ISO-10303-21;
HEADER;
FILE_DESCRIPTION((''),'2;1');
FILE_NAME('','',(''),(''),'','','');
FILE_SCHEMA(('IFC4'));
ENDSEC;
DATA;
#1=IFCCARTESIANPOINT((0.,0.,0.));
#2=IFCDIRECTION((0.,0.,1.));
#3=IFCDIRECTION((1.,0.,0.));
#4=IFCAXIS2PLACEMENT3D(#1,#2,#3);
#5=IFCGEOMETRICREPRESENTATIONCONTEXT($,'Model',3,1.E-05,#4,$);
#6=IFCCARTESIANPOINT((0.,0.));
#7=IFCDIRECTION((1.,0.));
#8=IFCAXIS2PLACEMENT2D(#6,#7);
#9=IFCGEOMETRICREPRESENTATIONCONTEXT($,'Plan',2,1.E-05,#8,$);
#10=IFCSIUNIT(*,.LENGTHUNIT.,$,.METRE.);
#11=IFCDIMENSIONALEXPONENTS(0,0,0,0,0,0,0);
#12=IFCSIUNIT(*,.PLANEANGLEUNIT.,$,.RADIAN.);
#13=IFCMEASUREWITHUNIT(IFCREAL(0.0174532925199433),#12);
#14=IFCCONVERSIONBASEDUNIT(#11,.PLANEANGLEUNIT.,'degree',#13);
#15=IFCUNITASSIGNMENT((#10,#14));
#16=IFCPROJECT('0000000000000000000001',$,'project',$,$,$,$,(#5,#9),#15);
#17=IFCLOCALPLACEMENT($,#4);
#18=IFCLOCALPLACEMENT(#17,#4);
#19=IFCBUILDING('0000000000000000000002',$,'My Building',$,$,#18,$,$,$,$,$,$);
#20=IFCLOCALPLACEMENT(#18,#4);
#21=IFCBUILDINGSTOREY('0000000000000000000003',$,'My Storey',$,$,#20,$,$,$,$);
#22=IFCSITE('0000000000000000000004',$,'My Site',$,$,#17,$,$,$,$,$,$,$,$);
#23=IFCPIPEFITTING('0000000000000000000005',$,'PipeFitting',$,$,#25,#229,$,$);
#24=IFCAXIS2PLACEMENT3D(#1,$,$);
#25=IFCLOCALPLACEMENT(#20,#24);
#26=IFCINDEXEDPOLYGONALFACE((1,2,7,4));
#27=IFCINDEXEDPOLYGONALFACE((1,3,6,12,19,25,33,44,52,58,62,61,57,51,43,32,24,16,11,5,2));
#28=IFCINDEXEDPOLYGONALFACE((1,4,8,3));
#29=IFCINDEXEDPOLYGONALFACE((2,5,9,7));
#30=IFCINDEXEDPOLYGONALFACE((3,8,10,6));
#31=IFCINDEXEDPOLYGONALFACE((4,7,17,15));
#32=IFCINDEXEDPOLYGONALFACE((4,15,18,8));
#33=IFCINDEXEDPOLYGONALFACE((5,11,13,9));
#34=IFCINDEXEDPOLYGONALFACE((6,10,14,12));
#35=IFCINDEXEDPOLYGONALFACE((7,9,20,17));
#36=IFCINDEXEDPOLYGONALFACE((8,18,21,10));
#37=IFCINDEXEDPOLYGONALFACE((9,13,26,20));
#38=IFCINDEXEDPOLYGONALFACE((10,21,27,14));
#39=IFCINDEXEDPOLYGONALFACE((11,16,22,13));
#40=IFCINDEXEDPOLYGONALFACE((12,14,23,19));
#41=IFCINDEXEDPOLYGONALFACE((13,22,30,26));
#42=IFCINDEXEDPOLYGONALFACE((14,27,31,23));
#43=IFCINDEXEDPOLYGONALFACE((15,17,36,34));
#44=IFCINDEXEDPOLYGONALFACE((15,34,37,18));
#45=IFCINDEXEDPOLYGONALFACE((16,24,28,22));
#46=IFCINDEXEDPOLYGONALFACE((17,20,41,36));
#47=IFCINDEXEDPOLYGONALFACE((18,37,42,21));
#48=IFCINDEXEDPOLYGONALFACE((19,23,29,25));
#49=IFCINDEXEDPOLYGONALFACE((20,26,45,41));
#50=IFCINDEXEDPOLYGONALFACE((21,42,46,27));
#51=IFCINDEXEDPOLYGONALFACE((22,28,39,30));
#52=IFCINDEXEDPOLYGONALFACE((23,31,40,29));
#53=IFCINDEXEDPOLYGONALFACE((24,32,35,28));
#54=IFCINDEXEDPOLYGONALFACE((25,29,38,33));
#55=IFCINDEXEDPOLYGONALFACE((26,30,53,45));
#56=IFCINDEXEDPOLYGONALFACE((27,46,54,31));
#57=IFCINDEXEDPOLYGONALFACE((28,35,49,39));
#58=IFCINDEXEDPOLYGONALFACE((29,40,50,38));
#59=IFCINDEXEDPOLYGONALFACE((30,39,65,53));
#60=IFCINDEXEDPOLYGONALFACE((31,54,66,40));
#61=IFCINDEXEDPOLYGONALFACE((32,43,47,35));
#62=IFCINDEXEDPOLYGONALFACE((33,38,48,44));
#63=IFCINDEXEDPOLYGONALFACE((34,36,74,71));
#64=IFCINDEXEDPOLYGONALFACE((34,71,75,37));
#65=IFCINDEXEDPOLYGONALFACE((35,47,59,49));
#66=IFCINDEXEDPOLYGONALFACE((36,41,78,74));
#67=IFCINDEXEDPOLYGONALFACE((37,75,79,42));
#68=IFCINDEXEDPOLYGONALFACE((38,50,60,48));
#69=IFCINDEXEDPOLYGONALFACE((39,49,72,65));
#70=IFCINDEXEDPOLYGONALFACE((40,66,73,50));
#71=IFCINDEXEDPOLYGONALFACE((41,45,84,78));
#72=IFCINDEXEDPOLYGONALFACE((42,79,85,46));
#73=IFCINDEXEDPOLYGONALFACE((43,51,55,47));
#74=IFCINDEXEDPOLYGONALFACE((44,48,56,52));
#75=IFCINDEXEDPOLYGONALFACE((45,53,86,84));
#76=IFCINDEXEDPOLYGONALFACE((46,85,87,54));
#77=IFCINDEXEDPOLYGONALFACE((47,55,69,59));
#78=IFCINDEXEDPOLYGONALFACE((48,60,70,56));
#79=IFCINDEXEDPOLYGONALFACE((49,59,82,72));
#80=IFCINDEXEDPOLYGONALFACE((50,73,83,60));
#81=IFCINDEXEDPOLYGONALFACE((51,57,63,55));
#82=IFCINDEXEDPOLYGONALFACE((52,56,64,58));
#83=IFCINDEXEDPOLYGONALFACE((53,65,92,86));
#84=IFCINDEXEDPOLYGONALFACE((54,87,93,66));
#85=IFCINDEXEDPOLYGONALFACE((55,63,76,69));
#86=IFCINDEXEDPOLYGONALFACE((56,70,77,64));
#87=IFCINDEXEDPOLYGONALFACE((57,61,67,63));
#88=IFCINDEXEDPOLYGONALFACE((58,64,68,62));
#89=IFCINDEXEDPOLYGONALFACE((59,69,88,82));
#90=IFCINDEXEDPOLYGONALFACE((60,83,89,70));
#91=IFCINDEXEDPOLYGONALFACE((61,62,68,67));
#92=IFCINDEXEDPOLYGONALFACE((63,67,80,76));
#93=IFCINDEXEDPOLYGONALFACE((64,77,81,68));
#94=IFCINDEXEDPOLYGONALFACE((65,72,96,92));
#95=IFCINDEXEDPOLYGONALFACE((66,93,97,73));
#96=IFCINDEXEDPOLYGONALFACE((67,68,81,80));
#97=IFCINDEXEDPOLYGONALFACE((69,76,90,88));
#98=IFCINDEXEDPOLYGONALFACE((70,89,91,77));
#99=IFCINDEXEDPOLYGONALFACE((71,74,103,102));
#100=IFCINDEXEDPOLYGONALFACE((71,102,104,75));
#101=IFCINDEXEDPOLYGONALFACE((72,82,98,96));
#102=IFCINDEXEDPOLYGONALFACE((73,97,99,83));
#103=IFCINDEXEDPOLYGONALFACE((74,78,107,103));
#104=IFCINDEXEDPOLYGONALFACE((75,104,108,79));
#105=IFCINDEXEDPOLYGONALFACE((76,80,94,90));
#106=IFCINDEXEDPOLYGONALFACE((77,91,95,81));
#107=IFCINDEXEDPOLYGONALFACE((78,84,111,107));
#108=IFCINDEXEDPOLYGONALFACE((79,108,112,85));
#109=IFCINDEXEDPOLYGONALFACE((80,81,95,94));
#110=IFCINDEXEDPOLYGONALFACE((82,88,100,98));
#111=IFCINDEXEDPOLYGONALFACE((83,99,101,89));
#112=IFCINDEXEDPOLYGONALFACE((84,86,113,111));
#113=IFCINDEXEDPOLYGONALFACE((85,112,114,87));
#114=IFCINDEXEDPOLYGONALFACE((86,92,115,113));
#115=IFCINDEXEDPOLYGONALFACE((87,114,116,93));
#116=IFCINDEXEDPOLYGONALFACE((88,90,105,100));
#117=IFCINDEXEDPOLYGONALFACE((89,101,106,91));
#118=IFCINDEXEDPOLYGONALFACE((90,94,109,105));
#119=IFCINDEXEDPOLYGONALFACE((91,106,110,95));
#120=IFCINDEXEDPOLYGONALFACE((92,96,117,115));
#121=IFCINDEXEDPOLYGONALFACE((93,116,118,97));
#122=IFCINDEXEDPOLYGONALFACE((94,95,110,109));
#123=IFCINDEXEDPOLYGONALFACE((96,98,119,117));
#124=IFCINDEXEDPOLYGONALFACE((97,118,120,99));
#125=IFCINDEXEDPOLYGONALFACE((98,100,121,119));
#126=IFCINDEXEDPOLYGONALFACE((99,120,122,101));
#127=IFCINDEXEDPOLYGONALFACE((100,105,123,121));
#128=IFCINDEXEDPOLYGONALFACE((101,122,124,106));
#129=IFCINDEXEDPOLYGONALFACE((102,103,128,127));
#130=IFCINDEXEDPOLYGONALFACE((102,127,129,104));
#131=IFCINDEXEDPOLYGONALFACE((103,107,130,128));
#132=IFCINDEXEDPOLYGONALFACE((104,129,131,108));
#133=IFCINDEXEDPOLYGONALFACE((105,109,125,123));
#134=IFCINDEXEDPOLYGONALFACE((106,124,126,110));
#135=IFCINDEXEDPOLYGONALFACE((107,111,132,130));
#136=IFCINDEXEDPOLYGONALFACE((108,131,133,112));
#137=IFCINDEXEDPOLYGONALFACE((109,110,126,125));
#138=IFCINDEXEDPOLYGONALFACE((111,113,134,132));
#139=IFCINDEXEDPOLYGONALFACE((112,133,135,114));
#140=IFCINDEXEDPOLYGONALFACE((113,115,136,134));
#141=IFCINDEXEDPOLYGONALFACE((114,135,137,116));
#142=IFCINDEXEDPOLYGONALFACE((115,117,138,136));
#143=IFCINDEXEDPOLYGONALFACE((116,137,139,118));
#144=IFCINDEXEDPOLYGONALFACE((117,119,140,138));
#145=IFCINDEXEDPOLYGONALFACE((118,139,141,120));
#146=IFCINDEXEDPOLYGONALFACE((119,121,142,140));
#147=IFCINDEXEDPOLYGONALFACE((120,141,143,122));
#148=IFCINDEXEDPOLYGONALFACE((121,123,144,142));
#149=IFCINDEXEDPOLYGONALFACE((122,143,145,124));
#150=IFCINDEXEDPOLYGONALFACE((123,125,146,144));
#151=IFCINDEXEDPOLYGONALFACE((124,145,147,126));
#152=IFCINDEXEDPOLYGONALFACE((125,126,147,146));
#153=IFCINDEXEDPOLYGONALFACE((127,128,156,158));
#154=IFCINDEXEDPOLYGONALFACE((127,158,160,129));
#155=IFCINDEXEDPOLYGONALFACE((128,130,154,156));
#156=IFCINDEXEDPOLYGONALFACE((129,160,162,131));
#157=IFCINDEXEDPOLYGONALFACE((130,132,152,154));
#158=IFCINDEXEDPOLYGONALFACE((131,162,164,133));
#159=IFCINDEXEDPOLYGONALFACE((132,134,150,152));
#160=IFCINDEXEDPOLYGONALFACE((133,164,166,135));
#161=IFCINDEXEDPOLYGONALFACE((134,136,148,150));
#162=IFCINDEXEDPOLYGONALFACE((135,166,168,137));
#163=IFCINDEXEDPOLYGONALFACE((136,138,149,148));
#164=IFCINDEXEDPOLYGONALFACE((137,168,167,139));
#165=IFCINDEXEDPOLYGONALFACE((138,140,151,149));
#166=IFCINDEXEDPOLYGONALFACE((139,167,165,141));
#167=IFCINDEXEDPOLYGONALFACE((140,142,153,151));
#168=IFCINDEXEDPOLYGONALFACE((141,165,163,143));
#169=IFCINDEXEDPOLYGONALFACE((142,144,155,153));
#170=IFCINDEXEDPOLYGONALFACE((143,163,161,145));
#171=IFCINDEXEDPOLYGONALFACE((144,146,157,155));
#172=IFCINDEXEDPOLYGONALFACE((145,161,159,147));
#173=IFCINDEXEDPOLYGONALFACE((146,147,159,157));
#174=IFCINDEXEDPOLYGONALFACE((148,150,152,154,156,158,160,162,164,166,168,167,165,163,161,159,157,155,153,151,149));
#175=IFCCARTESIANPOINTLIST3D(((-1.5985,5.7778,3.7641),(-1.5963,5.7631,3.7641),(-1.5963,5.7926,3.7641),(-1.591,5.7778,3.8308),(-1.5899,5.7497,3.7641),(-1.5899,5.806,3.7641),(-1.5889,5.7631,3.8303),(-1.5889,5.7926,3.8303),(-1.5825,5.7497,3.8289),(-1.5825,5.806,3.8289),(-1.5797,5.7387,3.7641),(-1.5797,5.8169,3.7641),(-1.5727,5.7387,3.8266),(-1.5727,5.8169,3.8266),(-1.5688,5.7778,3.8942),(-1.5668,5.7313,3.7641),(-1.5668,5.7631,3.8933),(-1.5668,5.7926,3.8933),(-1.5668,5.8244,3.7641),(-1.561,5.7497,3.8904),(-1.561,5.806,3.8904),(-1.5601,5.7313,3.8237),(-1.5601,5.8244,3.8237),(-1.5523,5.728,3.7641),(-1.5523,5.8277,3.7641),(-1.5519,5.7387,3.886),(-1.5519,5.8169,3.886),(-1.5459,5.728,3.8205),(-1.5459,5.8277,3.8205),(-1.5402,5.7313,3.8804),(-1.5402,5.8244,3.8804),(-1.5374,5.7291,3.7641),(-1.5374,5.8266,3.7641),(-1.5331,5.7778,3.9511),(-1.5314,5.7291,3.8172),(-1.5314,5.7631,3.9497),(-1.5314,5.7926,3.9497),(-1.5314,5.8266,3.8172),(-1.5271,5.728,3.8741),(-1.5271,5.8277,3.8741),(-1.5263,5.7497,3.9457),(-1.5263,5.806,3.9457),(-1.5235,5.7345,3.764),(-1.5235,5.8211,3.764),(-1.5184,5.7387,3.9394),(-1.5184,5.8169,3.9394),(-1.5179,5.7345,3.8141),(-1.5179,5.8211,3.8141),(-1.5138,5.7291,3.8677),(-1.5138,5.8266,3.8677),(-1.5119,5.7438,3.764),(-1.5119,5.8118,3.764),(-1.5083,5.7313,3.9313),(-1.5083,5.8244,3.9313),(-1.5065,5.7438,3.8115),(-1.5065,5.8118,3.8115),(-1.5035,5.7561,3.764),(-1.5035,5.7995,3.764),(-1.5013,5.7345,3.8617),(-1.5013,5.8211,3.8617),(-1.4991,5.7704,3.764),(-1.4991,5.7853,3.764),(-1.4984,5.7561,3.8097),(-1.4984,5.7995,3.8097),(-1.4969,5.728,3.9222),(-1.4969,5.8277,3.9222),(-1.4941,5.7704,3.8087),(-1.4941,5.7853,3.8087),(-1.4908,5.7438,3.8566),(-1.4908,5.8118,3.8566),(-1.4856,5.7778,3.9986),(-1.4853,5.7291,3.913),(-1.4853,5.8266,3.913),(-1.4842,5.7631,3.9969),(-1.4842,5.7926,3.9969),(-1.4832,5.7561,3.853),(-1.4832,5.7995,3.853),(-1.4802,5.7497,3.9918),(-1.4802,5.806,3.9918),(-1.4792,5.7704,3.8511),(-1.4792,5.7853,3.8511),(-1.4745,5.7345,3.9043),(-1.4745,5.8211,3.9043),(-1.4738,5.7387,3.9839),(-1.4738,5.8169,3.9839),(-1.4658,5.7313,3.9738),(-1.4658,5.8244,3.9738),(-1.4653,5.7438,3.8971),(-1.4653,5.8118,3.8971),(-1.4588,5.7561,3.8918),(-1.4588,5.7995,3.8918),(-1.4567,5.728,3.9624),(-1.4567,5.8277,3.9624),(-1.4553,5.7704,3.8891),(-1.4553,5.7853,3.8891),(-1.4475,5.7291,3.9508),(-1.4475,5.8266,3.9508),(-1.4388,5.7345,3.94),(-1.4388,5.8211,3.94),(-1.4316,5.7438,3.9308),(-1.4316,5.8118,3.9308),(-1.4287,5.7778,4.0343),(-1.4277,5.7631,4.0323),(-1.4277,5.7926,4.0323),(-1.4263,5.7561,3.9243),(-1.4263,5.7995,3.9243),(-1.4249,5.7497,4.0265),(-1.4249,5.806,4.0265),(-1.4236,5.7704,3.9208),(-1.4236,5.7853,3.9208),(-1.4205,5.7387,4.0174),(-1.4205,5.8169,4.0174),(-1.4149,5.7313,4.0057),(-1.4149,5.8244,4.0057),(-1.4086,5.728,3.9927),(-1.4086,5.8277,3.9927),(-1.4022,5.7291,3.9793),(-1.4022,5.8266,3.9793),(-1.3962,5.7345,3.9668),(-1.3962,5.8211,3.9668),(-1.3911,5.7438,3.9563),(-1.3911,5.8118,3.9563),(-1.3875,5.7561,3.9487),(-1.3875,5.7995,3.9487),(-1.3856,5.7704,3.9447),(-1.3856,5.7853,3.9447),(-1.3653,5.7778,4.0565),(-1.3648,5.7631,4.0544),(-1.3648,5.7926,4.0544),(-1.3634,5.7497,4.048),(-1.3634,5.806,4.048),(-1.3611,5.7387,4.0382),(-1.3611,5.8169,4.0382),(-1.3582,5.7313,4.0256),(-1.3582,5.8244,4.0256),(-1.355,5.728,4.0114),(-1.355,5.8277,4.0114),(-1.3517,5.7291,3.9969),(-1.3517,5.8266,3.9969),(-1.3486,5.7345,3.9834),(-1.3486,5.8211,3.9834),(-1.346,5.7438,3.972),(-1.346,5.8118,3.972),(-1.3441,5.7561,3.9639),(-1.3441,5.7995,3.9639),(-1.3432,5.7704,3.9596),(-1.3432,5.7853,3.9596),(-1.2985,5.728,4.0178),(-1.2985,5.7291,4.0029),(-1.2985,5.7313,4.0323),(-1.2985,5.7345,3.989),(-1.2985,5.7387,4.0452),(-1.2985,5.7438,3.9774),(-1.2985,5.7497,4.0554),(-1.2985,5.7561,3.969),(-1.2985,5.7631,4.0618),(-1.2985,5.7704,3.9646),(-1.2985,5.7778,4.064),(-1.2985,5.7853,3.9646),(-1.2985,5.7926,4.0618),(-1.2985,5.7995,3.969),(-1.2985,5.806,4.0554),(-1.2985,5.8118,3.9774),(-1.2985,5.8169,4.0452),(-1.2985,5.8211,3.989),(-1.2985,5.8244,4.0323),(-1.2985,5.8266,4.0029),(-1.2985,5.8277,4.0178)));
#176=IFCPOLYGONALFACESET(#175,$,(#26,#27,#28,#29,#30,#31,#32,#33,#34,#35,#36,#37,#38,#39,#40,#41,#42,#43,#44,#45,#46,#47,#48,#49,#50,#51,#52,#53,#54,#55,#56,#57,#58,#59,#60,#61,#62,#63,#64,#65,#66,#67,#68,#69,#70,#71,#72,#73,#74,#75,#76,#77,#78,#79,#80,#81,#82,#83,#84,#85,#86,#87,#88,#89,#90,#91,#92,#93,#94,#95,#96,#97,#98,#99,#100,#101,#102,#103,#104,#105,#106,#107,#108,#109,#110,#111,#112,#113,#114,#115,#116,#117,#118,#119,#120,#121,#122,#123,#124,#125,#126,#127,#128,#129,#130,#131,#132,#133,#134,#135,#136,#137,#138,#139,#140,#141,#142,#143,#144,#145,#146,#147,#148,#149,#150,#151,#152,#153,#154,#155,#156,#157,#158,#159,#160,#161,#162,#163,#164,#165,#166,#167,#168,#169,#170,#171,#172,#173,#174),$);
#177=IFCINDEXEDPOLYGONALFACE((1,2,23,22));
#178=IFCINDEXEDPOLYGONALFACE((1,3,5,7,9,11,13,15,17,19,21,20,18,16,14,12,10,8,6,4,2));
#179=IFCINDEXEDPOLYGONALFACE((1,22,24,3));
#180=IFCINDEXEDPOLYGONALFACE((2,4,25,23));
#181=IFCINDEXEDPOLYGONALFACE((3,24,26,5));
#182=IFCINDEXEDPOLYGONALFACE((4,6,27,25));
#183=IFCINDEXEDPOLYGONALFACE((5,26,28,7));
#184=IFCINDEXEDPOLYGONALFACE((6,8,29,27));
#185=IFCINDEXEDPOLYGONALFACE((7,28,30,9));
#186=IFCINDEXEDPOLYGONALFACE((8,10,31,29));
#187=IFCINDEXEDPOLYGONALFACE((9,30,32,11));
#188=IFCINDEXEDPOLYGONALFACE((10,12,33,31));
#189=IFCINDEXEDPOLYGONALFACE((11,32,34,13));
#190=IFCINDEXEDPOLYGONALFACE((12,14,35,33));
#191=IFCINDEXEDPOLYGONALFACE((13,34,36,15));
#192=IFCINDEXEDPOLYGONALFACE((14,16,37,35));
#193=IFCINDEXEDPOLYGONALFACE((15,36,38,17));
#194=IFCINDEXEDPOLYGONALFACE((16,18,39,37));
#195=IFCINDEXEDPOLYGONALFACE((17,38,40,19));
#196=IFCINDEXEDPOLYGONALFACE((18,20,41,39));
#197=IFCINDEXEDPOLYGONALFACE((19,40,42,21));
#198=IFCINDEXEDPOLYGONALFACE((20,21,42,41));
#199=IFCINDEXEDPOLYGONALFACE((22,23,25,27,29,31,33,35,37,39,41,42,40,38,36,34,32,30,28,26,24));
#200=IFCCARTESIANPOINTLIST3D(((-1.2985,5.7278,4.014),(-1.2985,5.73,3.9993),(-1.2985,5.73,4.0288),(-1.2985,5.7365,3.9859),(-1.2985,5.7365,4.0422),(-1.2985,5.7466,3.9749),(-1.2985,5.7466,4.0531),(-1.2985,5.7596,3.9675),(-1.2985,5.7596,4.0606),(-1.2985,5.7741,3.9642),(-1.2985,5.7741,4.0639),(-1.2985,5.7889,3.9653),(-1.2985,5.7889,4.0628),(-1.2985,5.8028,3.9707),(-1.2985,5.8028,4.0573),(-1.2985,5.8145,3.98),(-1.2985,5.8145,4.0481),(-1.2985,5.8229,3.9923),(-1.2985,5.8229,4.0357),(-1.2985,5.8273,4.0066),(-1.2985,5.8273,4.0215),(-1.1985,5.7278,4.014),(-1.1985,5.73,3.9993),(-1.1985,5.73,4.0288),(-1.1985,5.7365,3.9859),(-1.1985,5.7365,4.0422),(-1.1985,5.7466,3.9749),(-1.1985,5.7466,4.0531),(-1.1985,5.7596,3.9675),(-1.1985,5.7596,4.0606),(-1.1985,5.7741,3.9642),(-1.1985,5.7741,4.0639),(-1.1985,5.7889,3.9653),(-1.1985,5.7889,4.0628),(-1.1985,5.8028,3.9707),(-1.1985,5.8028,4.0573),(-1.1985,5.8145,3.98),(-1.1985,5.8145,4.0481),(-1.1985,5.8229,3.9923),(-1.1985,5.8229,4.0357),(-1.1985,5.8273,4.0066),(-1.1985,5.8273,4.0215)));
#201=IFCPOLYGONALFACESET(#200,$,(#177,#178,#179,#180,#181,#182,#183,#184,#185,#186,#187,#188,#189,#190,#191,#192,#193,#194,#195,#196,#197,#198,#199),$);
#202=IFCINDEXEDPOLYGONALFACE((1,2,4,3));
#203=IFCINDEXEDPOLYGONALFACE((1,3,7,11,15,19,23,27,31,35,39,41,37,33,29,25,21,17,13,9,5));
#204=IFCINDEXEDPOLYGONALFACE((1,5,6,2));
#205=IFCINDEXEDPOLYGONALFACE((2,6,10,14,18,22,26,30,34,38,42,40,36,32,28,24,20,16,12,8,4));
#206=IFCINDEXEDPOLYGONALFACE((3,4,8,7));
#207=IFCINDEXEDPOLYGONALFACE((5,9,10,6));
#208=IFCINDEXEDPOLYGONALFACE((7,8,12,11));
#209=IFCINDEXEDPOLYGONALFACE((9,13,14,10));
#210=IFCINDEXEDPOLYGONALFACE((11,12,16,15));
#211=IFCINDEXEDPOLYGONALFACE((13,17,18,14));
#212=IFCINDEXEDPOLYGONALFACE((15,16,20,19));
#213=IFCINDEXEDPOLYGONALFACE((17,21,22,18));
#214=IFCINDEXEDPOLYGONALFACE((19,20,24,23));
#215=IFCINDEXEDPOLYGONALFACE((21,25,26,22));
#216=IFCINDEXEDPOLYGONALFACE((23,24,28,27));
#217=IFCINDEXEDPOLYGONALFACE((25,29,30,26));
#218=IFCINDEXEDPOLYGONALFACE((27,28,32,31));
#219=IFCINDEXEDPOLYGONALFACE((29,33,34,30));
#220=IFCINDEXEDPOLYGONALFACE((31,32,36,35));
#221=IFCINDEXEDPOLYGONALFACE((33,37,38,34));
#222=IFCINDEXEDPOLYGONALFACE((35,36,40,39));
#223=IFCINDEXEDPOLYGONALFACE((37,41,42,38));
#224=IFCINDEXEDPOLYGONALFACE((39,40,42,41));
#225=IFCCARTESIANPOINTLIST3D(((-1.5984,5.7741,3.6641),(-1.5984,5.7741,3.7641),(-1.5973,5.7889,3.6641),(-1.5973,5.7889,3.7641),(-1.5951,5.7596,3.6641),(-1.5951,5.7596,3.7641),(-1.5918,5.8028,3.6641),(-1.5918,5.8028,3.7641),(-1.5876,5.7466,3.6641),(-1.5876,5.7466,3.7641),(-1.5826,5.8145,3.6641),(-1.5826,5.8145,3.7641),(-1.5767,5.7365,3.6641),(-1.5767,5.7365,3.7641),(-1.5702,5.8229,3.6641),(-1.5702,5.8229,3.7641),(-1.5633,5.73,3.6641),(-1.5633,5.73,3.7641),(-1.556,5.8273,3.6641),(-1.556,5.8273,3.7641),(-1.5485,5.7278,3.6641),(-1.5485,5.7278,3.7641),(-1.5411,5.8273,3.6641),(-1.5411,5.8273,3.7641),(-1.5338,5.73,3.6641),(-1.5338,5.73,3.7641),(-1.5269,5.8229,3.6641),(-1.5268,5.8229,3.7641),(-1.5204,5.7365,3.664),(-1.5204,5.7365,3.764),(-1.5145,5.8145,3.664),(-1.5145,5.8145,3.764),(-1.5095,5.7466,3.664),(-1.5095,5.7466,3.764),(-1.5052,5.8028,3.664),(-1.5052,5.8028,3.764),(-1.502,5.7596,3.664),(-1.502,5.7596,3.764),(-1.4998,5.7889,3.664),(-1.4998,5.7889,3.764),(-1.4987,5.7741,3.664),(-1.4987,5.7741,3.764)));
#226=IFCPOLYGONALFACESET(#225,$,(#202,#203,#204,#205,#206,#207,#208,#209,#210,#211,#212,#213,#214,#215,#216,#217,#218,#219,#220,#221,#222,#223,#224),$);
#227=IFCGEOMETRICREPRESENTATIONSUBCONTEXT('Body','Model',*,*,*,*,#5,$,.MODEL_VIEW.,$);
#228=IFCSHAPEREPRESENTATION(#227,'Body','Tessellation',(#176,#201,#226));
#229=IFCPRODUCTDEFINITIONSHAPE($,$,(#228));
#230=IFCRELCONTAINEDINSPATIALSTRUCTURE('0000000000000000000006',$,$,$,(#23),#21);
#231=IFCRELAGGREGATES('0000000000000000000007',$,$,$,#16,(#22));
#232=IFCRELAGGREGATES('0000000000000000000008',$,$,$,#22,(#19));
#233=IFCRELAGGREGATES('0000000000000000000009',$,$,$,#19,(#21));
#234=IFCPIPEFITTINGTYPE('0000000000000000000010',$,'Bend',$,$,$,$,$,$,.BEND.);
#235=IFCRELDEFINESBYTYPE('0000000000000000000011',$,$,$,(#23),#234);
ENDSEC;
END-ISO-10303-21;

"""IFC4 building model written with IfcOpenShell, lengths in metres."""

from ifc_helpers import new_model, entity, si_unit, converted_unit, frame, origin_with_axes, origin_2d_with_axis, place, context, subcontext, project, spatial, circle, extrude, source, transform, mapped, type_object, type_shapes, element, save


model = new_model("IFC4")

# Units and contexts
model_context = context("Model", 3, precision=1e-05, world=origin_with_axes())
plan_context = context("Plan", 2, precision=1e-05, world=origin_2d_with_axis())
body_context = subcontext(model_context, "Body", "Model", "MODEL_VIEW")
ifc_project = project(units=[si_unit("LENGTHUNIT", "METRE"), converted_unit("PLANEANGLEUNIT", "degree", entity("IfcReal", 0.0174532925199433), si_unit("PLANEANGLEUNIT", "RADIAN"), dimensions=[0, 0, 0, 0, 0, 0, 0])], contexts=[model_context, plan_context])

# Site, building, storey
site_placement = place(None, origin_with_axes())
site = spatial("IfcSite", under=ifc_project, at=site_placement, Name="My Site")
building_placement = place(site_placement, origin_with_axes())
building = spatial("IfcBuilding", under=site, at=building_placement, Name="My Building")
storey_placement = place(building_placement, origin_with_axes())
storey = spatial("IfcBuildingStorey", under=building, at=storey_placement, Name="My Storey")

# Pipe fitting
pipe_fitting_type_1 = type_object("IfcPipeFittingType", Name="Bend", PredefinedType="BEND")
shared_shape_1 = source(origin_with_axes(), body_context, "Body", "SolidModel", [
    entity("IfcSweptDiskSolid", entity("IfcIndexedPolyCurve", entity("IfcCartesianPointList3D", [[0.0, 0.0, 0.1], [0.0, -0.0732, 0.2768], [0.0, -0.25, 0.35]]), [entity("IfcArcIndex", [1, 2, 3])]), 0.05),
    extrude(circle(Radius=0.05), origin_with_axes(), (0.0, 0.0, 1.0), 0.1),
    extrude(circle(Radius=0.05), frame((0.0, -0.25, 0.35), z_axis=(0.0, -1.0, 0.000038), x_axis=(1.0, 0.0, 0.0)), (0.0, 0.0, 1.0), 0.1),
])
type_shapes(pipe_fitting_type_1, [shared_shape_1])
for number, where, z_axis, x_axis, name in (
    (1, (-1.1985, 5.7778, 4.014), (-1.0, 0.0, 0.0), (0.0, -1.0, 0.0), "PipeFitting"),
):
    element("IfcPipeFitting", number, at=place(storey_placement, frame(where, z_axis=z_axis, x_axis=x_axis)), inside=storey, type_object=pipe_fitting_type_1, Name=name, context=body_context, shape_type="MappedRepresentation", body=[
        mapped(shared_shape_1, transform((0.0, 0.0, 0.0), x_axis=(1.0, 0.0, 0.0), y_axis=(0.0, 1.0, 0.0), z_axis=(0.0, 0.0, 1.0), scale=1.0)),
    ])

save(model, "model.ifc")
